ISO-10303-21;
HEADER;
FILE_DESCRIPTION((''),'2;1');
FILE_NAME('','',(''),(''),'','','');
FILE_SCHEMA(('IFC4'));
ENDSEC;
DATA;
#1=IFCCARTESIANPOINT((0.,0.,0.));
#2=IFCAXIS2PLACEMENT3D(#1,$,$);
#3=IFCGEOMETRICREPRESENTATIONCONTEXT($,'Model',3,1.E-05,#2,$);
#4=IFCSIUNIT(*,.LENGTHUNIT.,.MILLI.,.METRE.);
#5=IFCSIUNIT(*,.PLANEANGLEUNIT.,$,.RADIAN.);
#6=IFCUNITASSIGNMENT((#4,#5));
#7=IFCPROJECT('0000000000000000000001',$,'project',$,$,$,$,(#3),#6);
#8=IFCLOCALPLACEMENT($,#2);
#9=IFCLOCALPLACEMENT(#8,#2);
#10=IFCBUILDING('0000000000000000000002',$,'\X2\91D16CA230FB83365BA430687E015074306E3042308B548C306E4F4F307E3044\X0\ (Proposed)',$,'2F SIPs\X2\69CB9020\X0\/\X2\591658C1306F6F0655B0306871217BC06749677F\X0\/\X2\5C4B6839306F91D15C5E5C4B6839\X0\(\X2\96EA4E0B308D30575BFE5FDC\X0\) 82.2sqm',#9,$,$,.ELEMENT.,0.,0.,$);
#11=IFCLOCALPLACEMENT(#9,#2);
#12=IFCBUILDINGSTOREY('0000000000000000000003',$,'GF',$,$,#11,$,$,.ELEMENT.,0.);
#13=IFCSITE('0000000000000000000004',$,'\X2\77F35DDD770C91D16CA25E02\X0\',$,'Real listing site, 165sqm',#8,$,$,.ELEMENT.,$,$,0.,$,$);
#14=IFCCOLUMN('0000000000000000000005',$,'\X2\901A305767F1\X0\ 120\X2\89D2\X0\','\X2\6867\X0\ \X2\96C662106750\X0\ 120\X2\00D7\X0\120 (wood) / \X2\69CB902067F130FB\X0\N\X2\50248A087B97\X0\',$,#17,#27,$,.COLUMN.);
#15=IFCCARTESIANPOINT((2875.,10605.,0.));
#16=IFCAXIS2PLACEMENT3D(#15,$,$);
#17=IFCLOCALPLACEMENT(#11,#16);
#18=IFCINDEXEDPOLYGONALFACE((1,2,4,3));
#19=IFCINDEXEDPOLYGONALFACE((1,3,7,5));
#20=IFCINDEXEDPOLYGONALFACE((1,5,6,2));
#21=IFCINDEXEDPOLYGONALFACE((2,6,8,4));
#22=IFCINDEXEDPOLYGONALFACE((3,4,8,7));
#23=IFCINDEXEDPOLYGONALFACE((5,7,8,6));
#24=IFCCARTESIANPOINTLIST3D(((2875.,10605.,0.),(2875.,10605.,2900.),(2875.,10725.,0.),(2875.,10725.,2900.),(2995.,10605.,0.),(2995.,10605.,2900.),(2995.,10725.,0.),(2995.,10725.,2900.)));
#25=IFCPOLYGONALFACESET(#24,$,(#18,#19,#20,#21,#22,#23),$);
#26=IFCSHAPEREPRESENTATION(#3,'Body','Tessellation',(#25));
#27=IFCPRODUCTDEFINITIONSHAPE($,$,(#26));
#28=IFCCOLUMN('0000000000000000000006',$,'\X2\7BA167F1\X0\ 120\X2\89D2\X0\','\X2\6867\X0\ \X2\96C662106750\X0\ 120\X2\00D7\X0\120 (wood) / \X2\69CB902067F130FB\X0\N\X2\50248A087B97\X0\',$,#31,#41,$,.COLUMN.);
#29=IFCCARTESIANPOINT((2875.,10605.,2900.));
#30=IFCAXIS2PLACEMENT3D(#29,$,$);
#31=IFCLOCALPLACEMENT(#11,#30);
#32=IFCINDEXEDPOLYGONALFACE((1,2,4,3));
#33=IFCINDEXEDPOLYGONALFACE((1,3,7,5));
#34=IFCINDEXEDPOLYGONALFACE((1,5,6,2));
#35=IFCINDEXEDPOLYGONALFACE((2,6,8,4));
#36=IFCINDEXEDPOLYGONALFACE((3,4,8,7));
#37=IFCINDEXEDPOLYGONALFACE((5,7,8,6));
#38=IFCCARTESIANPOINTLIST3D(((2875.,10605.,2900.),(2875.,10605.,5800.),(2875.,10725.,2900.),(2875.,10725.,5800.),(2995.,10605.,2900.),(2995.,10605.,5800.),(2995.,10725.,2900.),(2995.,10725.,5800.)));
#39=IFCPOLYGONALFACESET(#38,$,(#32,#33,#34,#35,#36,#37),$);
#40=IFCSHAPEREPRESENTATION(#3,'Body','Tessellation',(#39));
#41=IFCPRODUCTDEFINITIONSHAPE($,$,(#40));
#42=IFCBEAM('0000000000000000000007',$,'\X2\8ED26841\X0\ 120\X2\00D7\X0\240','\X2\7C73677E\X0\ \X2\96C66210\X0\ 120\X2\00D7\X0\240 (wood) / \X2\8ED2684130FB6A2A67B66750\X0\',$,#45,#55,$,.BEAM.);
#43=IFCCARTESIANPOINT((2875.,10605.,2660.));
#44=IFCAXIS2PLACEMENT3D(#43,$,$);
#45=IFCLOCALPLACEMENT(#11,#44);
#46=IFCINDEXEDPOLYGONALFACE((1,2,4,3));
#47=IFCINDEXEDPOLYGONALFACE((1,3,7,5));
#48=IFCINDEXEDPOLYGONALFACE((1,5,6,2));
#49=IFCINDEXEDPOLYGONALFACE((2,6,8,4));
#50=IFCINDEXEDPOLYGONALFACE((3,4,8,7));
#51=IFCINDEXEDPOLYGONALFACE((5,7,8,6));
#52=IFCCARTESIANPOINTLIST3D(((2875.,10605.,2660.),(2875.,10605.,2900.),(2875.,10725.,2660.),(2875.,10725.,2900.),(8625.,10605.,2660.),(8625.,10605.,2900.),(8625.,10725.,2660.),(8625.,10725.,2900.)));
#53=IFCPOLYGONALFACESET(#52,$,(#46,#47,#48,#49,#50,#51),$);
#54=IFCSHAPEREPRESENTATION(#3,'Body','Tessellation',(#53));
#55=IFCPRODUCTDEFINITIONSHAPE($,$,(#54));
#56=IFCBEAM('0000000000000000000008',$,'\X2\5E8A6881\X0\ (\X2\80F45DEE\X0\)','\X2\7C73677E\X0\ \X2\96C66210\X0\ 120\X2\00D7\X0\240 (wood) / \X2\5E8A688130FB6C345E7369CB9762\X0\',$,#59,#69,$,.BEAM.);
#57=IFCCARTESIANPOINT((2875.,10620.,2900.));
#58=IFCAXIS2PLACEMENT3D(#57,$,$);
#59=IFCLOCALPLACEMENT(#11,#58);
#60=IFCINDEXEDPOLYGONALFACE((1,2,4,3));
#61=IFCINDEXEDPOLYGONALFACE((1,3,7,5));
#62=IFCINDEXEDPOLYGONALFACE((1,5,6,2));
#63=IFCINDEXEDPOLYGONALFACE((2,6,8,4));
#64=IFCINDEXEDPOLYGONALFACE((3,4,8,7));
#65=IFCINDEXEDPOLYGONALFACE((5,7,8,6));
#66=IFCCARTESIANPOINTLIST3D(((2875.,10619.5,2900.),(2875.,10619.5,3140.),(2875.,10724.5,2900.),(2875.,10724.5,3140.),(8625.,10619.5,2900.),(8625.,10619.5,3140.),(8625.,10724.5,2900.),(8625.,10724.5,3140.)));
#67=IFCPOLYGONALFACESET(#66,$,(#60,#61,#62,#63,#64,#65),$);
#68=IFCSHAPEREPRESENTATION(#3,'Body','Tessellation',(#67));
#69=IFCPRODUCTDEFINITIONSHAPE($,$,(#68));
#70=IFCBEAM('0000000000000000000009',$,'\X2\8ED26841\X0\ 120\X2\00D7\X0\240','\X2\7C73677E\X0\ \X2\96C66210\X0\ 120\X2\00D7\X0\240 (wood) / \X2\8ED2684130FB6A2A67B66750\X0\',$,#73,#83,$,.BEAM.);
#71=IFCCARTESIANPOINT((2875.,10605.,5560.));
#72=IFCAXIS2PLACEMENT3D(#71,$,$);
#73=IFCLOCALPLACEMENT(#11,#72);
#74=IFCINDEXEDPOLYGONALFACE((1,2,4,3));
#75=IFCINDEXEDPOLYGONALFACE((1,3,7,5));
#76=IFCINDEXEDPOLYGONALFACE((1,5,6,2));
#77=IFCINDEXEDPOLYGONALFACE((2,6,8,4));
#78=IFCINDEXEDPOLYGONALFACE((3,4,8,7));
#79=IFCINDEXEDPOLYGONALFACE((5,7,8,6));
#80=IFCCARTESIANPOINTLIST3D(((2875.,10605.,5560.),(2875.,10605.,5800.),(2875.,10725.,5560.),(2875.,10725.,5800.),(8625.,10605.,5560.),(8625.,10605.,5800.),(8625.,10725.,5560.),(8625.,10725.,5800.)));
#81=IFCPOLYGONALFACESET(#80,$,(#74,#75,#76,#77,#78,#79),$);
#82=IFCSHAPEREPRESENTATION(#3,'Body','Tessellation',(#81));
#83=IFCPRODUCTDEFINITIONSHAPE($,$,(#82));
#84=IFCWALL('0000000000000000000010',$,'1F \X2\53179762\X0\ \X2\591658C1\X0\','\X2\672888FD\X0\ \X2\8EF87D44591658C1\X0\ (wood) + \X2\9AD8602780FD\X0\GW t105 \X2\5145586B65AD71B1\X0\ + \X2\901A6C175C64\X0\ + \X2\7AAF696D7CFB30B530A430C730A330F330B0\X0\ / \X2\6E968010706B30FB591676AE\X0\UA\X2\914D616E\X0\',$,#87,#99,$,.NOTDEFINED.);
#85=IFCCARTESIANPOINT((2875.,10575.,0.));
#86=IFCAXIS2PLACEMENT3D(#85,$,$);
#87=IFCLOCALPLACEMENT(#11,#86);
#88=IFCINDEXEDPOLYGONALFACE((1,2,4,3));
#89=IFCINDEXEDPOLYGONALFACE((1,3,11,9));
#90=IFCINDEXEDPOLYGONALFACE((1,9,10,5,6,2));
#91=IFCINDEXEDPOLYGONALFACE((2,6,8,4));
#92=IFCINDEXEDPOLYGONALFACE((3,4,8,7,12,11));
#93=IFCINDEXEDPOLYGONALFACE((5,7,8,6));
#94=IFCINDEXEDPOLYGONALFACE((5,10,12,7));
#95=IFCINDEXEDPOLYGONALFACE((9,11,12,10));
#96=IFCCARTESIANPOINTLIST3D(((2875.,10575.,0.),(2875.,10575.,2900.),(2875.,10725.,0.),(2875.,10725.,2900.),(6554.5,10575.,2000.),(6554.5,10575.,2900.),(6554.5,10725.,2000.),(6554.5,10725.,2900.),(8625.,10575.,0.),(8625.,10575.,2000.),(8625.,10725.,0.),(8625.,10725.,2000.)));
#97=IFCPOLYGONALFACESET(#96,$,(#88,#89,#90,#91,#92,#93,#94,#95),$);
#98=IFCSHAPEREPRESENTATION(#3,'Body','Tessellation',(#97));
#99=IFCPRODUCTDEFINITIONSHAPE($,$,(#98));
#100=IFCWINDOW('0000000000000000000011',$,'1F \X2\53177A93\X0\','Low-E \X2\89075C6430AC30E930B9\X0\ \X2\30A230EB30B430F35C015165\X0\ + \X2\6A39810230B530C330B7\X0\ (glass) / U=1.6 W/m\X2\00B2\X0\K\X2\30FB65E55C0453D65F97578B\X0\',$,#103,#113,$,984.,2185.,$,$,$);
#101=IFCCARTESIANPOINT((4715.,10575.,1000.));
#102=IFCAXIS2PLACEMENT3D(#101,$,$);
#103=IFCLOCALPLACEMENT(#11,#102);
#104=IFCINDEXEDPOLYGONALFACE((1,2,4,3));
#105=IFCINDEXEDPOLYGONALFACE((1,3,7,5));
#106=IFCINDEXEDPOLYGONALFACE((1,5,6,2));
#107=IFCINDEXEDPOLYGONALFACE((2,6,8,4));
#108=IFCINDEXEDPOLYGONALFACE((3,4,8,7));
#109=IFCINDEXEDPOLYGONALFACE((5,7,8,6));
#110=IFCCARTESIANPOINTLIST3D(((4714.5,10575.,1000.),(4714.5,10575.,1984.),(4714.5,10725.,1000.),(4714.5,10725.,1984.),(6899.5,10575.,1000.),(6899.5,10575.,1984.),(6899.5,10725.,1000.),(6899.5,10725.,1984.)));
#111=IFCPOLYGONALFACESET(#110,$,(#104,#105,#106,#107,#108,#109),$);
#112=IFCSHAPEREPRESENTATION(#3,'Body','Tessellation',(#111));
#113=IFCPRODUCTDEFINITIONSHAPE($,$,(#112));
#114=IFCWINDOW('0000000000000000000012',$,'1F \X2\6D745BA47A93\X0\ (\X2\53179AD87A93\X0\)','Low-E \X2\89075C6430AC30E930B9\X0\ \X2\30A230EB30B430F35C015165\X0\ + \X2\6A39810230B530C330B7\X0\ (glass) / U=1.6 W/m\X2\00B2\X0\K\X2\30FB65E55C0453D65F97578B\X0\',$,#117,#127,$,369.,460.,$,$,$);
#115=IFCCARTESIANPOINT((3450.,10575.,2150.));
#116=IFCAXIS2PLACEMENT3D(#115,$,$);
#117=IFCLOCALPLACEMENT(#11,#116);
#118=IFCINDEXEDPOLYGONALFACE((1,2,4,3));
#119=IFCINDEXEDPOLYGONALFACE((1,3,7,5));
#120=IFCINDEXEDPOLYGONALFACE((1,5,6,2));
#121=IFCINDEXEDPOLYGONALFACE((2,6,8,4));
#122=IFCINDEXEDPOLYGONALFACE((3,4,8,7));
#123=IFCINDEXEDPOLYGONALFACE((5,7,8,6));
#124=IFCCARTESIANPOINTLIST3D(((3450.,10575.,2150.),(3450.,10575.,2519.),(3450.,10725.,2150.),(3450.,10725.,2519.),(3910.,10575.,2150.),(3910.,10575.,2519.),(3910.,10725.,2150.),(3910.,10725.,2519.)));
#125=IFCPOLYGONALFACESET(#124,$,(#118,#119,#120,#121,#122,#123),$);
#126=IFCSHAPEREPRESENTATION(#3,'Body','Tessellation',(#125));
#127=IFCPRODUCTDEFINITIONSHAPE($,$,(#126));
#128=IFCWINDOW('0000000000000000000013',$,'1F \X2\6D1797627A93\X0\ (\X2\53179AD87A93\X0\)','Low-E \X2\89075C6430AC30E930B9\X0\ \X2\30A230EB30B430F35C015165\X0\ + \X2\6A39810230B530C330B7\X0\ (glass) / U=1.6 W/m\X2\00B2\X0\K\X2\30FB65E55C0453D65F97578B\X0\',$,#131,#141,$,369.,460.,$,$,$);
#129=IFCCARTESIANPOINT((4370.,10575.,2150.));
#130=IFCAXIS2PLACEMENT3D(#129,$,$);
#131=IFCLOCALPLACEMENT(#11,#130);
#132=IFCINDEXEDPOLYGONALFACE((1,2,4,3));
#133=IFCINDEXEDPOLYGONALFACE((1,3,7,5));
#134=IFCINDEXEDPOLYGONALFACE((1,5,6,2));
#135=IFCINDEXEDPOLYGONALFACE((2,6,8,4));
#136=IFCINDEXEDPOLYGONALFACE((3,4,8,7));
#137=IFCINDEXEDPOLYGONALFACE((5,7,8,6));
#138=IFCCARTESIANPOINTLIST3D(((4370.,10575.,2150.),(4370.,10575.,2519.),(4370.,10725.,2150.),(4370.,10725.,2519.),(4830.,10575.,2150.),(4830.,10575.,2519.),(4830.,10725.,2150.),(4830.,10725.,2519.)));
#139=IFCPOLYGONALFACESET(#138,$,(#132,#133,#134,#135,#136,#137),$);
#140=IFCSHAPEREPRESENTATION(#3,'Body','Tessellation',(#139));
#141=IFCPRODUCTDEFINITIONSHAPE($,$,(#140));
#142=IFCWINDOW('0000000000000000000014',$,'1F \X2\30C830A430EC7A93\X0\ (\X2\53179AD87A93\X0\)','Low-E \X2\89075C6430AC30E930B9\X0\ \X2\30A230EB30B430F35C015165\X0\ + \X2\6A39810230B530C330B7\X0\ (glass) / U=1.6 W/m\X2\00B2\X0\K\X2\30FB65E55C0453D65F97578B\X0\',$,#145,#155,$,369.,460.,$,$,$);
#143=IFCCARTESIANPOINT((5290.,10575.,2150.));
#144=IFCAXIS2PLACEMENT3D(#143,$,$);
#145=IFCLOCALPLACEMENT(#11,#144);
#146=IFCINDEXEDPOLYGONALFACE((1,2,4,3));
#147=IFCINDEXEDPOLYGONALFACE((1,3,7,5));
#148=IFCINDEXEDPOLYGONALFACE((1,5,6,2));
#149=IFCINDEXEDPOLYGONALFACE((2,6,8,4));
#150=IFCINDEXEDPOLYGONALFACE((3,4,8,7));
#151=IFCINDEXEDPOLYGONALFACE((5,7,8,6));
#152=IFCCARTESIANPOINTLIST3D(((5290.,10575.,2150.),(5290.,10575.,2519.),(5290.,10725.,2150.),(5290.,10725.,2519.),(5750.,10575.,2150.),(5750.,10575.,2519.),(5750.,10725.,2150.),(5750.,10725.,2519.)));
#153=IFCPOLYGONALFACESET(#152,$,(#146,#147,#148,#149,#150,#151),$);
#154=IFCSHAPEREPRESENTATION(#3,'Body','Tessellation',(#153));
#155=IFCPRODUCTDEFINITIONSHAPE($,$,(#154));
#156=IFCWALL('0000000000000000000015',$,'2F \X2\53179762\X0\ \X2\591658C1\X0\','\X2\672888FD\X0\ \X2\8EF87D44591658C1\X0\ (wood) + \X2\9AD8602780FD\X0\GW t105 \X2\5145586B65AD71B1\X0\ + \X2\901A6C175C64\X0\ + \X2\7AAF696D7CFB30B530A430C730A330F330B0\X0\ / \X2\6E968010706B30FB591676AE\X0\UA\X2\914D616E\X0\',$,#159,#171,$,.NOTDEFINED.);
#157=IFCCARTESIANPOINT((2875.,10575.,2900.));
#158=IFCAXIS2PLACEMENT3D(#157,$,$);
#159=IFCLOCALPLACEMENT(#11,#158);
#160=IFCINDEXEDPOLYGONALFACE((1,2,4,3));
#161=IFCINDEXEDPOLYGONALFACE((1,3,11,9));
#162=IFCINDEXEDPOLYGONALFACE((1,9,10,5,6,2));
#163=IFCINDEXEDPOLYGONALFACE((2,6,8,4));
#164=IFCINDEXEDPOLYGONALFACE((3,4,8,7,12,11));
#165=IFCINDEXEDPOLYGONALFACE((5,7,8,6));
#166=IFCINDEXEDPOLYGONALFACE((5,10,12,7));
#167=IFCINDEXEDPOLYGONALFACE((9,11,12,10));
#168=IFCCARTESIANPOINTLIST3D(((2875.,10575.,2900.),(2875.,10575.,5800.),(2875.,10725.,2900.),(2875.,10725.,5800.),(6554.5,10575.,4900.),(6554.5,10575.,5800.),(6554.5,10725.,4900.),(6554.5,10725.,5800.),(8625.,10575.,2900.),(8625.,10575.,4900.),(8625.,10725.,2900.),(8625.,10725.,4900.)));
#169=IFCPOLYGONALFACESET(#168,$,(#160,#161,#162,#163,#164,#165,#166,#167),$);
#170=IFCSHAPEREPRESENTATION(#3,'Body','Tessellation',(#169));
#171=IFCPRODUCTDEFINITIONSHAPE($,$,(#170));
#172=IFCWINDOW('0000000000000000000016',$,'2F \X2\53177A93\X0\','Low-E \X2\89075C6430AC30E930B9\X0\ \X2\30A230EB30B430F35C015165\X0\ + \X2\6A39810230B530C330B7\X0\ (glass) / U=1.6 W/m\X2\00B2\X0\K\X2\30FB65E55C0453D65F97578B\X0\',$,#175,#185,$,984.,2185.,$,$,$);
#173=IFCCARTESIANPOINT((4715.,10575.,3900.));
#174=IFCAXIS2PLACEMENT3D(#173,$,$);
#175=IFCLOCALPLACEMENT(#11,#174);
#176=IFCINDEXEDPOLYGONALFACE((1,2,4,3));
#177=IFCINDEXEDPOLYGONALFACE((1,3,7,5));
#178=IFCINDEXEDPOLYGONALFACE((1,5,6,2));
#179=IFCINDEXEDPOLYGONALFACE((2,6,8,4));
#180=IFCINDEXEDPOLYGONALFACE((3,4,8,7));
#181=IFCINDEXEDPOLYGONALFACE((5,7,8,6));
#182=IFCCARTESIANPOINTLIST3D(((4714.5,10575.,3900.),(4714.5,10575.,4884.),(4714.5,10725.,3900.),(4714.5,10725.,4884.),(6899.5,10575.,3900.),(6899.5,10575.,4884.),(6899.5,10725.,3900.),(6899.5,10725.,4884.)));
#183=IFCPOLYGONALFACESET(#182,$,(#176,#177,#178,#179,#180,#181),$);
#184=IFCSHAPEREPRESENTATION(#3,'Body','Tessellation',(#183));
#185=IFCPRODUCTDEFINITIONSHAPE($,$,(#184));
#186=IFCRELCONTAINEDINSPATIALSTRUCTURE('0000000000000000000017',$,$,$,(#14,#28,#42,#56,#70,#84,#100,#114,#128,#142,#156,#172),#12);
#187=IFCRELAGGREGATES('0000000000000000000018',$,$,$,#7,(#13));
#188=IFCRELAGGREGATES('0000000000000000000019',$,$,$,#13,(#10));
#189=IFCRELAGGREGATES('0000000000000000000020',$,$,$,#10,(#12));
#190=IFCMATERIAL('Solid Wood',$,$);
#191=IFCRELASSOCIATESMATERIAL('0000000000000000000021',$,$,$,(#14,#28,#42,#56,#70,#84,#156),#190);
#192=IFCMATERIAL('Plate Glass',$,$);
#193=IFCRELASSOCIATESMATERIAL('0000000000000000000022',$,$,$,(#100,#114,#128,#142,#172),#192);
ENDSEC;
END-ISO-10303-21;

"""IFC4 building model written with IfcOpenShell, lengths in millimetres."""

from ifc_helpers import new_model, si_unit, frame, frame_2d, origin, place, context, project, spatial, rectangle, extrude, material, element, fill, save


model = new_model("IFC4")

# Units and contexts
model_context = context("Model", 3, precision=1e-05, world=origin())
ifc_project = project(units=[si_unit("LENGTHUNIT", "METRE", prefix="MILLI"), si_unit("PLANEANGLEUNIT", "RADIAN")], contexts=[model_context])

# Site, building, storey
site_placement = place(None, origin())
site = spatial("IfcSite", under=ifc_project, at=site_placement, Name="石川県金沢市", ObjectType="Real listing site, 165sqm", CompositionType="ELEMENT", RefElevation=0.0)
building_placement = place(site_placement, origin())
building = spatial("IfcBuilding", under=site, at=building_placement, Name="金沢・茶室と縁側のある和の住まい (Proposed)", ObjectType="2F SIPs構造/外壁は漆喰と無節杉板/屋根は金属屋根(雪下ろし対応) 82.2sqm", CompositionType="ELEMENT", ElevationOfRefHeight=0.0, ElevationOfTerrain=0.0)
storey_placement = place(building_placement, origin())
storey = spatial("IfcBuildingStorey", under=building, at=storey_placement, Name="GF", CompositionType="ELEMENT", Elevation=0.0)

# Columns
ifc_material_1 = material(Name="Solid Wood")
column_1_placement = place(storey_placement, frame((2875.0, 10605.0, 0.0)))
element("IfcColumn", 1, at=column_1_placement, inside=storey, material=ifc_material_1, Name="通し柱 120角", Description="桧 集成材 120×120 (wood) / 構造柱・N値計算", PredefinedType="COLUMN", context=model_context, shape_type="SweptSolid", body=[
    extrude(rectangle(XDim=120.0, YDim=120.0, at=frame_2d((60.0, 60.0))), frame((2875.0, 10605.0, 0.0)), (0.0, 0.0, 1.0), 2900.0),
])
column_2_placement = place(storey_placement, frame((2875.0, 10605.0, 2900.0)))
element("IfcColumn", 2, at=column_2_placement, inside=storey, material=ifc_material_1, Name="管柱 120角", Description="桧 集成材 120×120 (wood) / 構造柱・N値計算", PredefinedType="COLUMN", context=model_context, shape_type="SweptSolid", body=[
    extrude(rectangle(XDim=120.0, YDim=120.0, at=frame_2d((60.0, 60.0))), frame((2875.0, 10605.0, 2900.0)), (0.0, 0.0, 1.0), 2900.0),
])

# Beams
beam_1_placement = place(storey_placement, frame((2875.0, 10605.0, 2660.0)))
element("IfcBeam", 3, at=beam_1_placement, inside=storey, material=ifc_material_1, Name="軒桁 120×240", Description="米松 集成 120×240 (wood) / 軒桁・横架材", PredefinedType="BEAM", context=model_context, shape_type="SweptSolid", body=[
    extrude(rectangle(XDim=5750.0, YDim=120.0, at=frame_2d((2875.0, 60.0))), frame((2875.0, 10605.0, 2660.0)), (0.0, 0.0, 1.0), 240.0),
])
beam_2_placement = place(storey_placement, frame((2875.0, 10620.0, 2900.0)))
element("IfcBeam", 4, at=beam_2_placement, inside=storey, material=ifc_material_1, Name="床梁 (胴差)", Description="米松 集成 120×240 (wood) / 床梁・水平構面", PredefinedType="BEAM", context=model_context, shape_type="SweptSolid", body=[
    extrude(rectangle(XDim=5750.0, YDim=105.0, at=frame_2d((2875.0, 52.0))), frame((2875.0, 10620.0, 2900.0)), (0.0, 0.0, 1.0), 240.0),
])
beam_3_placement = place(storey_placement, frame((2875.0, 10605.0, 5560.0)))
element("IfcBeam", 5, at=beam_3_placement, inside=storey, material=ifc_material_1, Name="軒桁 120×240", Description="米松 集成 120×240 (wood) / 軒桁・横架材", PredefinedType="BEAM", context=model_context, shape_type="SweptSolid", body=[
    extrude(rectangle(XDim=5750.0, YDim=120.0, at=frame_2d((2875.0, 60.0))), frame((2875.0, 10605.0, 5560.0)), (0.0, 0.0, 1.0), 240.0),
])

# Wall, openings, windows
wall_1_placement = place(storey_placement, frame((2875.0, 10575.0, 0.0)))
wall_1 = element("IfcWall", 6, at=wall_1_placement, inside=storey, material=ifc_material_1, Name="1F 北面 外壁", Description="木製 軸組外壁 (wood) + 高性能GW t105 充填断熱 + 通気層 + 窯業系サイディング / 準耐火・外皮UA配慮", PredefinedType="NOTDEFINED", context=model_context, shape_type="SweptSolid", body=[
    extrude(rectangle(XDim=5750.0, YDim=150.0, at=frame_2d((2875.0, 75.0))), frame((2875.0, 10575.0, 0.0)), (0.0, 0.0, 1.0), 2900.0),
])
opening_1_placement = place(storey_placement, frame((4715.0, 10575.0, 1000.0)))
opening_1 = element("IfcOpeningElement", 7, at=opening_1_placement, cuts=wall_1, PredefinedType="NOTDEFINED", context=model_context, shape_type="SweptSolid", body=[
    extrude(rectangle(XDim=2185.0, YDim=150.0, at=frame_2d((1092.0, 75.0))), frame((4715.0, 10575.0, 1000.0)), (0.0, 0.0, 1.0), 984.0),
])
opening_2_placement = place(storey_placement, frame((3450.0, 10575.0, 2150.0)))
opening_2 = element("IfcOpeningElement", 8, at=opening_2_placement, cuts=wall_1, PredefinedType="NOTDEFINED", context=model_context, shape_type="SweptSolid", body=[
    extrude(rectangle(XDim=460.0, YDim=150.0, at=frame_2d((230.0, 75.0))), frame((3450.0, 10575.0, 2150.0)), (0.0, 0.0, 1.0), 369.0),
])
opening_3_placement = place(storey_placement, frame((4370.0, 10575.0, 2150.0)))
opening_3 = element("IfcOpeningElement", 9, at=opening_3_placement, cuts=wall_1, PredefinedType="NOTDEFINED", context=model_context, shape_type="SweptSolid", body=[
    extrude(rectangle(XDim=460.0, YDim=150.0, at=frame_2d((230.0, 75.0))), frame((4370.0, 10575.0, 2150.0)), (0.0, 0.0, 1.0), 369.0),
])
opening_4_placement = place(storey_placement, frame((5290.0, 10575.0, 2150.0)))
opening_4 = element("IfcOpeningElement", 10, at=opening_4_placement, cuts=wall_1, PredefinedType="NOTDEFINED", context=model_context, shape_type="SweptSolid", body=[
    extrude(rectangle(XDim=460.0, YDim=150.0, at=frame_2d((230.0, 75.0))), frame((5290.0, 10575.0, 2150.0)), (0.0, 0.0, 1.0), 369.0),
])
ifc_material_2 = material(Name="Plate Glass")
window_1_placement = place(storey_placement, frame((4715.0, 10575.0, 1000.0)))
window_1 = element("IfcWindow", 11, at=window_1_placement, inside=storey, material=ifc_material_2, Name="1F 北窓", Description="Low-E 複層ガラス アルゴン封入 + 樹脂サッシ (glass) / U=1.6 W/m²K・日射取得型", OverallHeight=984.0, OverallWidth=2185.0, context=model_context, shape_type="SweptSolid", body=[
    extrude(rectangle(XDim=2185.0, YDim=150.0, at=frame_2d((1092.0, 75.0))), frame((4715.0, 10575.0, 1000.0)), (0.0, 0.0, 1.0), 984.0),
])
fill(opening_1, window_1)
window_2_placement = place(storey_placement, frame((3450.0, 10575.0, 2150.0)))
window_2 = element("IfcWindow", 12, at=window_2_placement, inside=storey, material=ifc_material_2, Name="1F 浴室窓 (北高窓)", Description="Low-E 複層ガラス アルゴン封入 + 樹脂サッシ (glass) / U=1.6 W/m²K・日射取得型", OverallHeight=369.0, OverallWidth=460.0, context=model_context, shape_type="SweptSolid", body=[
    extrude(rectangle(XDim=460.0, YDim=150.0, at=frame_2d((230.0, 75.0))), frame((3450.0, 10575.0, 2150.0)), (0.0, 0.0, 1.0), 369.0),
])
fill(opening_2, window_2)
window_3_placement = place(storey_placement, frame((4370.0, 10575.0, 2150.0)))
window_3 = element("IfcWindow", 13, at=window_3_placement, inside=storey, material=ifc_material_2, Name="1F 洗面窓 (北高窓)", Description="Low-E 複層ガラス アルゴン封入 + 樹脂サッシ (glass) / U=1.6 W/m²K・日射取得型", OverallHeight=369.0, OverallWidth=460.0, context=model_context, shape_type="SweptSolid", body=[
    extrude(rectangle(XDim=460.0, YDim=150.0, at=frame_2d((230.0, 75.0))), frame((4370.0, 10575.0, 2150.0)), (0.0, 0.0, 1.0), 369.0),
])
fill(opening_3, window_3)
window_4_placement = place(storey_placement, frame((5290.0, 10575.0, 2150.0)))
window_4 = element("IfcWindow", 14, at=window_4_placement, inside=storey, material=ifc_material_2, Name="1F トイレ窓 (北高窓)", Description="Low-E 複層ガラス アルゴン封入 + 樹脂サッシ (glass) / U=1.6 W/m²K・日射取得型", OverallHeight=369.0, OverallWidth=460.0, context=model_context, shape_type="SweptSolid", body=[
    extrude(rectangle(XDim=460.0, YDim=150.0, at=frame_2d((230.0, 75.0))), frame((5290.0, 10575.0, 2150.0)), (0.0, 0.0, 1.0), 369.0),
])
fill(opening_4, window_4)

# Wall, opening, window
wall_2_placement = place(storey_placement, frame((2875.0, 10575.0, 2900.0)))
wall_2 = element("IfcWall", 15, at=wall_2_placement, inside=storey, material=ifc_material_1, Name="2F 北面 外壁", Description="木製 軸組外壁 (wood) + 高性能GW t105 充填断熱 + 通気層 + 窯業系サイディング / 準耐火・外皮UA配慮", PredefinedType="NOTDEFINED", context=model_context, shape_type="SweptSolid", body=[
    extrude(rectangle(XDim=5750.0, YDim=150.0, at=frame_2d((2875.0, 75.0))), frame((2875.0, 10575.0, 2900.0)), (0.0, 0.0, 1.0), 2900.0),
])
opening_5_placement = place(storey_placement, frame((4715.0, 10575.0, 3900.0)))
opening_5 = element("IfcOpeningElement", 16, at=opening_5_placement, cuts=wall_2, PredefinedType="NOTDEFINED", context=model_context, shape_type="SweptSolid", body=[
    extrude(rectangle(XDim=2185.0, YDim=150.0, at=frame_2d((1092.0, 75.0))), frame((4715.0, 10575.0, 3900.0)), (0.0, 0.0, 1.0), 984.0),
])
window_5_placement = place(storey_placement, frame((4715.0, 10575.0, 3900.0)))
window_5 = element("IfcWindow", 17, at=window_5_placement, inside=storey, material=ifc_material_2, Name="2F 北窓", Description="Low-E 複層ガラス アルゴン封入 + 樹脂サッシ (glass) / U=1.6 W/m²K・日射取得型", OverallHeight=984.0, OverallWidth=2185.0, context=model_context, shape_type="SweptSolid", body=[
    extrude(rectangle(XDim=2185.0, YDim=150.0, at=frame_2d((1092.0, 75.0))), frame((4715.0, 10575.0, 3900.0)), (0.0, 0.0, 1.0), 984.0),
])
fill(opening_5, window_5)

save(model, "model.ifc")
